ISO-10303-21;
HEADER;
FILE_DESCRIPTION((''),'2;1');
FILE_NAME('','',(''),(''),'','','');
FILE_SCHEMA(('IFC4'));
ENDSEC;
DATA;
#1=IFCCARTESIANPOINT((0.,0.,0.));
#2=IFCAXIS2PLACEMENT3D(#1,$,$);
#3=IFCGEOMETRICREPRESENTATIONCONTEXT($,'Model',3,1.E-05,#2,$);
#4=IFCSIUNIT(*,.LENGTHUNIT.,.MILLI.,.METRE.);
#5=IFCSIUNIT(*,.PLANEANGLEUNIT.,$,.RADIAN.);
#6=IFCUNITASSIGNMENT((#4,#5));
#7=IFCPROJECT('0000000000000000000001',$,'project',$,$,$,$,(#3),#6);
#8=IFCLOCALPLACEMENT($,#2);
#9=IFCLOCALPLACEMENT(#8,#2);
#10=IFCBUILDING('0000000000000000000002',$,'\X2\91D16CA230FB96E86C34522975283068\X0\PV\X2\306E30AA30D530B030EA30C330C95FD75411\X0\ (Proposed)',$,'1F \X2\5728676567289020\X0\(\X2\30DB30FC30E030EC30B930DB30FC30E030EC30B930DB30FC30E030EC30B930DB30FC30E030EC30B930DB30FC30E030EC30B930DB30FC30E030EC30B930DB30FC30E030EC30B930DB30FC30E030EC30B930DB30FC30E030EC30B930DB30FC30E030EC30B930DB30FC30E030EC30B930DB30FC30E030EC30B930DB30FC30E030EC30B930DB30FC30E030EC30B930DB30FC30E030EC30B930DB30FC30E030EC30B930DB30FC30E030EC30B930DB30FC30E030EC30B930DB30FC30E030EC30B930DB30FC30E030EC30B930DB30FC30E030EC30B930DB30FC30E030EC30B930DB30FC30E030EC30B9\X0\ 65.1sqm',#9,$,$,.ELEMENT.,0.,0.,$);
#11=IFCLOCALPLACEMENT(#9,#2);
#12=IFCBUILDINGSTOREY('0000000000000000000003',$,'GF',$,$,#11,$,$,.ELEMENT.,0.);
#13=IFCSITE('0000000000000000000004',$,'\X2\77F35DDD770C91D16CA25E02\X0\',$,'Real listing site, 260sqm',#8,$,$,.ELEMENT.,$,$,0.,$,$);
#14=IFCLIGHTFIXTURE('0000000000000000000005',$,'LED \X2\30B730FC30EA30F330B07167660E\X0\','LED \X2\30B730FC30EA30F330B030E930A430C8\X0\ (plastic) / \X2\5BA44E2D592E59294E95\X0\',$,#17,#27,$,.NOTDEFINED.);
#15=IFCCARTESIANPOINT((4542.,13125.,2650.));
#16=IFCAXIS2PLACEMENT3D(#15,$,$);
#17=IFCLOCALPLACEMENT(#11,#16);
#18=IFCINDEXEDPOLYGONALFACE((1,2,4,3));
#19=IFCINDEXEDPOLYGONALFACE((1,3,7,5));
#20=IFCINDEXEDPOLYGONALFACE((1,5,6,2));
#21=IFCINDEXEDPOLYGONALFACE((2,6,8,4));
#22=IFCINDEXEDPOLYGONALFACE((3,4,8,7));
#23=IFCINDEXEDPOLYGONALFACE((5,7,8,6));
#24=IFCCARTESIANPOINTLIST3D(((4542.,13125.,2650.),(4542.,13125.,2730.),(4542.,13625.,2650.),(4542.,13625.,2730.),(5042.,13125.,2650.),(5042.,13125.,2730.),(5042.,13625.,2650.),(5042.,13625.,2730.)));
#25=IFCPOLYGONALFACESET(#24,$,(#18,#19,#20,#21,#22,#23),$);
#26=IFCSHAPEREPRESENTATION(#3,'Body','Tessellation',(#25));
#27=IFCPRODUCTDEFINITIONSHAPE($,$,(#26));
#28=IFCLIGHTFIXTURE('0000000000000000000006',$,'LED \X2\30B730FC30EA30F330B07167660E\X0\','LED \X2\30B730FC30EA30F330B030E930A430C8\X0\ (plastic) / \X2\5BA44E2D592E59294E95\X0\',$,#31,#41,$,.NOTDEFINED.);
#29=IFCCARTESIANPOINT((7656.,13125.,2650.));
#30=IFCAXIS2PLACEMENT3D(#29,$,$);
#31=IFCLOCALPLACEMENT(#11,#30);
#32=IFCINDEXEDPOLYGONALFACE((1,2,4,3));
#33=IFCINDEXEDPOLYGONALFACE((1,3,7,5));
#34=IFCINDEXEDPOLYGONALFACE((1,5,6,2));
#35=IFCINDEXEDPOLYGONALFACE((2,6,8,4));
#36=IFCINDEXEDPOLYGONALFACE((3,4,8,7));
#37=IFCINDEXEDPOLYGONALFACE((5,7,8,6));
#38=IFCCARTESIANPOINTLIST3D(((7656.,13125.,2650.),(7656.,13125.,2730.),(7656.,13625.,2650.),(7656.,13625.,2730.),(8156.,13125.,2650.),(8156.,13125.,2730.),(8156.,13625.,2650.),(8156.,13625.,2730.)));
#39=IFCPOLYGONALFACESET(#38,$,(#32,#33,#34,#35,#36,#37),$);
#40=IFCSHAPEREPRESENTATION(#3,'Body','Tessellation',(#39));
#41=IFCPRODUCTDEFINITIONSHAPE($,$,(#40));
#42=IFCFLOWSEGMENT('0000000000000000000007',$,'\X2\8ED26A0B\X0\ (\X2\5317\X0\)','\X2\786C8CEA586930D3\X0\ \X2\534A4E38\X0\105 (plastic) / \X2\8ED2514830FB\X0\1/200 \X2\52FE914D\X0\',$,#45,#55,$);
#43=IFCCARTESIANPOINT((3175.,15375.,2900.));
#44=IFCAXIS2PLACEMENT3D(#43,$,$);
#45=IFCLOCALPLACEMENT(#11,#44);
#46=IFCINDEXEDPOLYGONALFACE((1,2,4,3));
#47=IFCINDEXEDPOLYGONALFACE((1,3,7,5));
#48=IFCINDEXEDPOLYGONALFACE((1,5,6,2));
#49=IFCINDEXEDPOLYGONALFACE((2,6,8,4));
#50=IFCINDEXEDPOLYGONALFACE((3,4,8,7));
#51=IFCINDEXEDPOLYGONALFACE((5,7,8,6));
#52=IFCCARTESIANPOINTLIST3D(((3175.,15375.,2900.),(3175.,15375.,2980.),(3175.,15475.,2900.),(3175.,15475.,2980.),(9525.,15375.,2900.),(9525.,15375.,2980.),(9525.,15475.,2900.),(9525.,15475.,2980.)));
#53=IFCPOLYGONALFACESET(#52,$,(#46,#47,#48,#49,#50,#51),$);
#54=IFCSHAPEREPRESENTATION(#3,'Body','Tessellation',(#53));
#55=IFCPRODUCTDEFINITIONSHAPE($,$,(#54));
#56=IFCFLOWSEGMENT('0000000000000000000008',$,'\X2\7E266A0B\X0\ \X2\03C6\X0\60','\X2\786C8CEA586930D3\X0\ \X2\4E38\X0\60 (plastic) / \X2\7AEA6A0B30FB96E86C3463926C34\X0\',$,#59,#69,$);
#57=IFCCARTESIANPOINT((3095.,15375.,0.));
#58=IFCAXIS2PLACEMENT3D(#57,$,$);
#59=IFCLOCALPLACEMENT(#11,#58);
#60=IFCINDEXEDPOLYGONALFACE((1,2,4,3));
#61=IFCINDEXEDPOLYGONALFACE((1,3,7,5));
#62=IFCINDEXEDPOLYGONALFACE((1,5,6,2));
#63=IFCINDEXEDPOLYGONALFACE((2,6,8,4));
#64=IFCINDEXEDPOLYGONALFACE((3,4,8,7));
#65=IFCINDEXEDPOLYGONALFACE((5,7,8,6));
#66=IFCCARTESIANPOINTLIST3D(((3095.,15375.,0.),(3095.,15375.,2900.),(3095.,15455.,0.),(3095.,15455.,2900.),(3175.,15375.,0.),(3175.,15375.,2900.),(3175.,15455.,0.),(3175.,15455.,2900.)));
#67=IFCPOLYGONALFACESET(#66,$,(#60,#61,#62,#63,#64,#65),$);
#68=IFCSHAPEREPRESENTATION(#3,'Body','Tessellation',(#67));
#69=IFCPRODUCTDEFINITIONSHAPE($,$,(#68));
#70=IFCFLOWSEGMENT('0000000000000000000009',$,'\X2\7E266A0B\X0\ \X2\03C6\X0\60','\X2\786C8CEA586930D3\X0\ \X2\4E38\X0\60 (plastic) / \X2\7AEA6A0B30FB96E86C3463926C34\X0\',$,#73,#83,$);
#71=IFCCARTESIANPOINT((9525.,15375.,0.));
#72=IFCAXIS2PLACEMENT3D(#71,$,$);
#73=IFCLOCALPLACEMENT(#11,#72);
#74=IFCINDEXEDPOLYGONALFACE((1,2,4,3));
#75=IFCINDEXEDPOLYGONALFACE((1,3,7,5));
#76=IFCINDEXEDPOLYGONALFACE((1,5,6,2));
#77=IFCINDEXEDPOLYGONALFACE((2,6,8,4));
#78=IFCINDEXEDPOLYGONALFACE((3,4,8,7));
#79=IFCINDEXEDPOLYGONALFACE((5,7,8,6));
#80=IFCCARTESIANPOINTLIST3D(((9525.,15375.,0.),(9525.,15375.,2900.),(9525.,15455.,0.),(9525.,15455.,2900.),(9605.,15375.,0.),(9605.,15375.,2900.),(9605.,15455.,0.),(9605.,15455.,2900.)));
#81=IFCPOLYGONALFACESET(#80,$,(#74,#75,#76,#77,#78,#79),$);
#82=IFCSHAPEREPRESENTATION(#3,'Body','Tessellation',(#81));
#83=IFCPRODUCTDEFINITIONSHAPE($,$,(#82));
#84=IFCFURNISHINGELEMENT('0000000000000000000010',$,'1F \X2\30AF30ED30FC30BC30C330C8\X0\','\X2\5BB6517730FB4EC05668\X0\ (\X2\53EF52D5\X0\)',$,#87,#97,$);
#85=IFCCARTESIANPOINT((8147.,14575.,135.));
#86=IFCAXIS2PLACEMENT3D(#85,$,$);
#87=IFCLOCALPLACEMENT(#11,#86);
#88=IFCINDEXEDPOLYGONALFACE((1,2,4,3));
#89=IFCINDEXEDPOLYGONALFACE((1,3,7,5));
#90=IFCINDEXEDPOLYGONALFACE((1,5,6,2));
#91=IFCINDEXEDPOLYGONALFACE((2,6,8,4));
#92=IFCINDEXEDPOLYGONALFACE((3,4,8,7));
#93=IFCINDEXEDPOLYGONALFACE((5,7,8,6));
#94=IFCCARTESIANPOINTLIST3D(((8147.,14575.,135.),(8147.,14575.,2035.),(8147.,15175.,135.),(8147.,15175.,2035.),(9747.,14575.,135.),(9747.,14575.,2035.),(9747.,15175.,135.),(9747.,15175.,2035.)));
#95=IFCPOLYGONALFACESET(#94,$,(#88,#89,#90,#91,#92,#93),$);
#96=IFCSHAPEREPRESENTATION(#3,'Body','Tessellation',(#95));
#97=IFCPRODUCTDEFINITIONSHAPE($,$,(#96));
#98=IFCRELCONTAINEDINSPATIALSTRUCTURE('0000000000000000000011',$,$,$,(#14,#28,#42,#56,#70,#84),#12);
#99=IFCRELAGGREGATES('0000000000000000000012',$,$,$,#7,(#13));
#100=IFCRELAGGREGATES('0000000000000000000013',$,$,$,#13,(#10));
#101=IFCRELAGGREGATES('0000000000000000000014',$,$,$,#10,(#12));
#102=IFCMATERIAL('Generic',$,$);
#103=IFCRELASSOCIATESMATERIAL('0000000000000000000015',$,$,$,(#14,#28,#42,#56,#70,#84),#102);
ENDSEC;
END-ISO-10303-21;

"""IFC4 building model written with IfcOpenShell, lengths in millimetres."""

from ifc_helpers import new_model, si_unit, frame, frame_2d, origin, place, context, project, spatial, rectangle, extrude, material, element, save


model = new_model("IFC4")

# Units and contexts
model_context = context("Model", 3, precision=1e-05, world=origin())
ifc_project = project(units=[si_unit("LENGTHUNIT", "METRE", prefix="MILLI"), si_unit("PLANEANGLEUNIT", "RADIAN")], contexts=[model_context])

# Site, building, storey
site_placement = place(None, origin())
site = spatial("IfcSite", under=ifc_project, at=site_placement, Name="石川県金沢市", ObjectType="Real listing site, 260sqm", CompositionType="ELEMENT", RefElevation=0.0)
building_placement = place(site_placement, origin())
building = spatial("IfcBuilding", under=site, at=building_placement, Name="金沢・雨水利用とPVのオフグリッド志向 (Proposed)", ObjectType="1F 在来木造(ホームレスホームレスホームレスホームレスホームレスホームレスホームレスホームレスホームレスホームレスホームレスホームレスホームレスホームレスホームレスホームレスホームレスホームレスホームレスホームレスホームレスホームレスホームレス 65.1sqm", CompositionType="ELEMENT", ElevationOfRefHeight=0.0, ElevationOfTerrain=0.0)
storey_placement = place(building_placement, origin())
storey = spatial("IfcBuildingStorey", under=building, at=storey_placement, Name="GF", CompositionType="ELEMENT", Elevation=0.0)

# Shared definitions
ifc_material_1 = material(Name="Generic")

# Light fixtures
light_fixture_1_placement = place(storey_placement, frame((4542.0, 13125.0, 2650.0)))
element("IfcLightFixture", 1, at=light_fixture_1_placement, inside=storey, material=ifc_material_1, Name="LED シーリング照明", Description="LED シーリングライト (plastic) / 室中央天井", PredefinedType="NOTDEFINED", context=model_context, shape_type="SweptSolid", body=[
    extrude(rectangle(XDim=500.0, YDim=500.0, at=frame_2d((250.0, 250.0))), frame((4542.0, 13125.0, 2650.0)), (0.0, 0.0, 1.0), 80.0),
])
light_fixture_2_placement = place(storey_placement, frame((7656.0, 13125.0, 2650.0)))
element("IfcLightFixture", 2, at=light_fixture_2_placement, inside=storey, material=ifc_material_1, Name="LED シーリング照明", Description="LED シーリングライト (plastic) / 室中央天井", PredefinedType="NOTDEFINED", context=model_context, shape_type="SweptSolid", body=[
    extrude(rectangle(XDim=500.0, YDim=500.0, at=frame_2d((250.0, 250.0))), frame((7656.0, 13125.0, 2650.0)), (0.0, 0.0, 1.0), 80.0),
])

# Flow segments
flow_segment_1_placement = place(storey_placement, frame((3175.0, 15375.0, 2900.0)))
element("IfcFlowSegment", 3, at=flow_segment_1_placement, inside=storey, material=ifc_material_1, Name="軒樋 (北)", Description="硬質塩ビ 半丸105 (plastic) / 軒先・1/200 勾配", context=model_context, shape_type="SweptSolid", body=[
    extrude(rectangle(XDim=6350.0, YDim=100.0, at=frame_2d((3175.0, 50.0))), frame((3175.0, 15375.0, 2900.0)), (0.0, 0.0, 1.0), 80.0),
])
flow_segment_2_placement = place(storey_placement, frame((3095.0, 15375.0, 0.0)))
element("IfcFlowSegment", 4, at=flow_segment_2_placement, inside=storey, material=ifc_material_1, Name="縦樋 φ60", Description="硬質塩ビ 丸60 (plastic) / 竪樋・雨水排水", context=model_context, shape_type="SweptSolid", body=[
    extrude(rectangle(XDim=80.0, YDim=80.0, at=frame_2d((40.0, 40.0))), frame((3095.0, 15375.0, 0.0)), (0.0, 0.0, 1.0), 2900.0),
])
flow_segment_3_placement = place(storey_placement, frame((9525.0, 15375.0, 0.0)))
element("IfcFlowSegment", 5, at=flow_segment_3_placement, inside=storey, material=ifc_material_1, Name="縦樋 φ60", Description="硬質塩ビ 丸60 (plastic) / 竪樋・雨水排水", context=model_context, shape_type="SweptSolid", body=[
    extrude(rectangle(XDim=80.0, YDim=80.0, at=frame_2d((40.0, 40.0))), frame((9525.0, 15375.0, 0.0)), (0.0, 0.0, 1.0), 2900.0),
])

# Furnishing element
furnishing_placement = place(storey_placement, frame((8147.0, 14575.0, 135.0)))
element("IfcFurnishingElement", 6, at=furnishing_placement, inside=storey, material=ifc_material_1, Name="1F クローゼット", Description="家具・什器 (可動)", context=model_context, shape_type="SweptSolid", body=[
    extrude(rectangle(XDim=1600.0, YDim=600.0, at=frame_2d((800.0, 300.0))), frame((8147.0, 14575.0, 135.0)), (0.0, 0.0, 1.0), 1900.0),
])

save(model, "model.ifc")
